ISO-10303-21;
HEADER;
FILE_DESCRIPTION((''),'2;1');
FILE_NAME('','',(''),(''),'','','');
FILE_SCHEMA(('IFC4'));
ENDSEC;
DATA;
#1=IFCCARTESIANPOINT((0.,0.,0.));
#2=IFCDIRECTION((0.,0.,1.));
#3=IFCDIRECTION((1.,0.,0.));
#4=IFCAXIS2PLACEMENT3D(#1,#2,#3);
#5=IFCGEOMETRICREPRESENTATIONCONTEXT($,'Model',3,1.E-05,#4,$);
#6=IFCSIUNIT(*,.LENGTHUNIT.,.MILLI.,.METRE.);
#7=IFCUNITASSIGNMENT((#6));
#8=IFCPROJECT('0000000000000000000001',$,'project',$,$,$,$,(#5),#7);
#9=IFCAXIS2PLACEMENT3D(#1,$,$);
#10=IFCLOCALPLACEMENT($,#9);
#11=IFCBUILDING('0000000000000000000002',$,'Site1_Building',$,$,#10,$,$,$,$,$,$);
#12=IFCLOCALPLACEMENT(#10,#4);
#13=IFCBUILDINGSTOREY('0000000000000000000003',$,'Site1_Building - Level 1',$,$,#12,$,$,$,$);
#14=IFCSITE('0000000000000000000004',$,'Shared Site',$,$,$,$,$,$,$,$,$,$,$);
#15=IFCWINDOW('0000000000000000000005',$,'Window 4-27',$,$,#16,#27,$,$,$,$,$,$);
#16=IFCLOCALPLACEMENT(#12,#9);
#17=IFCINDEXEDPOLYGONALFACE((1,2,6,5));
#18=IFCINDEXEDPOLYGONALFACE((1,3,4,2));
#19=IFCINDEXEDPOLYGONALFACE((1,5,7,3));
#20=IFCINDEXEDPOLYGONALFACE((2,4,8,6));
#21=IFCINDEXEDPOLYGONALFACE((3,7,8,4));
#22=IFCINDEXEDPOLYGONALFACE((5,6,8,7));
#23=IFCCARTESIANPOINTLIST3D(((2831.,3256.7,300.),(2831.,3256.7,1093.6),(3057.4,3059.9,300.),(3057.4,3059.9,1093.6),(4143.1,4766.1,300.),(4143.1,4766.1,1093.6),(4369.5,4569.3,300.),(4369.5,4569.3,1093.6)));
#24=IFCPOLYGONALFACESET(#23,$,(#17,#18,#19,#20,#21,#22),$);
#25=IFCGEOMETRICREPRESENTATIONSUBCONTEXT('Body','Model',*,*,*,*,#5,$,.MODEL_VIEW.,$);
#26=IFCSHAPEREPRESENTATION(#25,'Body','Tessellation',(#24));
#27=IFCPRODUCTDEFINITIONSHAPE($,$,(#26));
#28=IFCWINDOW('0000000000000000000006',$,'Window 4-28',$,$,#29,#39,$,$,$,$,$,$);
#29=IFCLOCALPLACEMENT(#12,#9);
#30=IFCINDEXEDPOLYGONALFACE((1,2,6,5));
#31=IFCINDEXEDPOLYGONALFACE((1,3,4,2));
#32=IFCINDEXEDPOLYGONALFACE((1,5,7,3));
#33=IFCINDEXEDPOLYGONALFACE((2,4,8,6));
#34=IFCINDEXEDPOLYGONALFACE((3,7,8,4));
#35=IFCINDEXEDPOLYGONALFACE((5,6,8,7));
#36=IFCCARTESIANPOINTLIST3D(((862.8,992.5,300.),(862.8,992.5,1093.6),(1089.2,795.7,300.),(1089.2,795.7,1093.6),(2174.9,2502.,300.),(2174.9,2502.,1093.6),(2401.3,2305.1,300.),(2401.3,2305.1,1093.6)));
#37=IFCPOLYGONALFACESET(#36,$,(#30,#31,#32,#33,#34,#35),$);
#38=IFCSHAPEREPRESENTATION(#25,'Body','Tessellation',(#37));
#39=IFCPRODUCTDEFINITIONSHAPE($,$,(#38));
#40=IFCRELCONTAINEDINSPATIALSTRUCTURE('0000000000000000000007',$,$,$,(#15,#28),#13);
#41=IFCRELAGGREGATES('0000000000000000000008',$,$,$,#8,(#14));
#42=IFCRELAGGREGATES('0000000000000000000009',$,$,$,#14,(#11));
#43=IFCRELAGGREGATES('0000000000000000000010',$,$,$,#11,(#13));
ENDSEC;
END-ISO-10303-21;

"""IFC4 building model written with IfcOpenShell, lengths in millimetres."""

from ifc_helpers import new_model, si_unit, frame, origin, origin_with_axes, place, context, subcontext, project, spatial, indexed_curve, outline, extrude, element, save


model = new_model("IFC4")

# Units and contexts
model_context = context("Model", 3, precision=1e-05, world=origin_with_axes())
body_context = subcontext(model_context, "Body", "Model", "MODEL_VIEW")
ifc_project = project(units=[si_unit("LENGTHUNIT", "METRE", prefix="MILLI")], contexts=[model_context])

# Site, building, storey
site = spatial("IfcSite", under=ifc_project, Name="Shared Site")
building_placement = place(None, origin())
building = spatial("IfcBuilding", under=site, at=building_placement, Name="Site1_Building")
storey_placement = place(building_placement, origin_with_axes())
storey = spatial("IfcBuildingStorey", under=building, at=storey_placement, Name="Site1_Building - Level 1")

# Windows
for number, where, z_axis, x_axis, name in (
    (1, (4143.1, 4766.1, 300.0), (0.0, 0.0, 1.0), (-0.656059, -0.75471, 0.0), "Window 4-27"),
    (2, (2174.9, 2502.0, 300.0), (0.0, 0.0, 1.0), (-0.656059, -0.75471, 0.0), "Window 4-28"),
):
    element("IfcWindow", number, at=place(storey_placement, frame(where, z_axis=z_axis, x_axis=x_axis)), inside=storey, Name=name, context=body_context, shape_type="SweptSolid", body=[
        extrude(outline(indexed_curve([(0.0, 0.0), (0.0, 300.0), (2000.0, 300.0), (2000.0, 0.0), (0.0, 0.0)], self_intersect=False)), origin_with_axes(), (0.0, 0.0, 1.0), 793.6),
    ])

save(model, "model.ifc")
